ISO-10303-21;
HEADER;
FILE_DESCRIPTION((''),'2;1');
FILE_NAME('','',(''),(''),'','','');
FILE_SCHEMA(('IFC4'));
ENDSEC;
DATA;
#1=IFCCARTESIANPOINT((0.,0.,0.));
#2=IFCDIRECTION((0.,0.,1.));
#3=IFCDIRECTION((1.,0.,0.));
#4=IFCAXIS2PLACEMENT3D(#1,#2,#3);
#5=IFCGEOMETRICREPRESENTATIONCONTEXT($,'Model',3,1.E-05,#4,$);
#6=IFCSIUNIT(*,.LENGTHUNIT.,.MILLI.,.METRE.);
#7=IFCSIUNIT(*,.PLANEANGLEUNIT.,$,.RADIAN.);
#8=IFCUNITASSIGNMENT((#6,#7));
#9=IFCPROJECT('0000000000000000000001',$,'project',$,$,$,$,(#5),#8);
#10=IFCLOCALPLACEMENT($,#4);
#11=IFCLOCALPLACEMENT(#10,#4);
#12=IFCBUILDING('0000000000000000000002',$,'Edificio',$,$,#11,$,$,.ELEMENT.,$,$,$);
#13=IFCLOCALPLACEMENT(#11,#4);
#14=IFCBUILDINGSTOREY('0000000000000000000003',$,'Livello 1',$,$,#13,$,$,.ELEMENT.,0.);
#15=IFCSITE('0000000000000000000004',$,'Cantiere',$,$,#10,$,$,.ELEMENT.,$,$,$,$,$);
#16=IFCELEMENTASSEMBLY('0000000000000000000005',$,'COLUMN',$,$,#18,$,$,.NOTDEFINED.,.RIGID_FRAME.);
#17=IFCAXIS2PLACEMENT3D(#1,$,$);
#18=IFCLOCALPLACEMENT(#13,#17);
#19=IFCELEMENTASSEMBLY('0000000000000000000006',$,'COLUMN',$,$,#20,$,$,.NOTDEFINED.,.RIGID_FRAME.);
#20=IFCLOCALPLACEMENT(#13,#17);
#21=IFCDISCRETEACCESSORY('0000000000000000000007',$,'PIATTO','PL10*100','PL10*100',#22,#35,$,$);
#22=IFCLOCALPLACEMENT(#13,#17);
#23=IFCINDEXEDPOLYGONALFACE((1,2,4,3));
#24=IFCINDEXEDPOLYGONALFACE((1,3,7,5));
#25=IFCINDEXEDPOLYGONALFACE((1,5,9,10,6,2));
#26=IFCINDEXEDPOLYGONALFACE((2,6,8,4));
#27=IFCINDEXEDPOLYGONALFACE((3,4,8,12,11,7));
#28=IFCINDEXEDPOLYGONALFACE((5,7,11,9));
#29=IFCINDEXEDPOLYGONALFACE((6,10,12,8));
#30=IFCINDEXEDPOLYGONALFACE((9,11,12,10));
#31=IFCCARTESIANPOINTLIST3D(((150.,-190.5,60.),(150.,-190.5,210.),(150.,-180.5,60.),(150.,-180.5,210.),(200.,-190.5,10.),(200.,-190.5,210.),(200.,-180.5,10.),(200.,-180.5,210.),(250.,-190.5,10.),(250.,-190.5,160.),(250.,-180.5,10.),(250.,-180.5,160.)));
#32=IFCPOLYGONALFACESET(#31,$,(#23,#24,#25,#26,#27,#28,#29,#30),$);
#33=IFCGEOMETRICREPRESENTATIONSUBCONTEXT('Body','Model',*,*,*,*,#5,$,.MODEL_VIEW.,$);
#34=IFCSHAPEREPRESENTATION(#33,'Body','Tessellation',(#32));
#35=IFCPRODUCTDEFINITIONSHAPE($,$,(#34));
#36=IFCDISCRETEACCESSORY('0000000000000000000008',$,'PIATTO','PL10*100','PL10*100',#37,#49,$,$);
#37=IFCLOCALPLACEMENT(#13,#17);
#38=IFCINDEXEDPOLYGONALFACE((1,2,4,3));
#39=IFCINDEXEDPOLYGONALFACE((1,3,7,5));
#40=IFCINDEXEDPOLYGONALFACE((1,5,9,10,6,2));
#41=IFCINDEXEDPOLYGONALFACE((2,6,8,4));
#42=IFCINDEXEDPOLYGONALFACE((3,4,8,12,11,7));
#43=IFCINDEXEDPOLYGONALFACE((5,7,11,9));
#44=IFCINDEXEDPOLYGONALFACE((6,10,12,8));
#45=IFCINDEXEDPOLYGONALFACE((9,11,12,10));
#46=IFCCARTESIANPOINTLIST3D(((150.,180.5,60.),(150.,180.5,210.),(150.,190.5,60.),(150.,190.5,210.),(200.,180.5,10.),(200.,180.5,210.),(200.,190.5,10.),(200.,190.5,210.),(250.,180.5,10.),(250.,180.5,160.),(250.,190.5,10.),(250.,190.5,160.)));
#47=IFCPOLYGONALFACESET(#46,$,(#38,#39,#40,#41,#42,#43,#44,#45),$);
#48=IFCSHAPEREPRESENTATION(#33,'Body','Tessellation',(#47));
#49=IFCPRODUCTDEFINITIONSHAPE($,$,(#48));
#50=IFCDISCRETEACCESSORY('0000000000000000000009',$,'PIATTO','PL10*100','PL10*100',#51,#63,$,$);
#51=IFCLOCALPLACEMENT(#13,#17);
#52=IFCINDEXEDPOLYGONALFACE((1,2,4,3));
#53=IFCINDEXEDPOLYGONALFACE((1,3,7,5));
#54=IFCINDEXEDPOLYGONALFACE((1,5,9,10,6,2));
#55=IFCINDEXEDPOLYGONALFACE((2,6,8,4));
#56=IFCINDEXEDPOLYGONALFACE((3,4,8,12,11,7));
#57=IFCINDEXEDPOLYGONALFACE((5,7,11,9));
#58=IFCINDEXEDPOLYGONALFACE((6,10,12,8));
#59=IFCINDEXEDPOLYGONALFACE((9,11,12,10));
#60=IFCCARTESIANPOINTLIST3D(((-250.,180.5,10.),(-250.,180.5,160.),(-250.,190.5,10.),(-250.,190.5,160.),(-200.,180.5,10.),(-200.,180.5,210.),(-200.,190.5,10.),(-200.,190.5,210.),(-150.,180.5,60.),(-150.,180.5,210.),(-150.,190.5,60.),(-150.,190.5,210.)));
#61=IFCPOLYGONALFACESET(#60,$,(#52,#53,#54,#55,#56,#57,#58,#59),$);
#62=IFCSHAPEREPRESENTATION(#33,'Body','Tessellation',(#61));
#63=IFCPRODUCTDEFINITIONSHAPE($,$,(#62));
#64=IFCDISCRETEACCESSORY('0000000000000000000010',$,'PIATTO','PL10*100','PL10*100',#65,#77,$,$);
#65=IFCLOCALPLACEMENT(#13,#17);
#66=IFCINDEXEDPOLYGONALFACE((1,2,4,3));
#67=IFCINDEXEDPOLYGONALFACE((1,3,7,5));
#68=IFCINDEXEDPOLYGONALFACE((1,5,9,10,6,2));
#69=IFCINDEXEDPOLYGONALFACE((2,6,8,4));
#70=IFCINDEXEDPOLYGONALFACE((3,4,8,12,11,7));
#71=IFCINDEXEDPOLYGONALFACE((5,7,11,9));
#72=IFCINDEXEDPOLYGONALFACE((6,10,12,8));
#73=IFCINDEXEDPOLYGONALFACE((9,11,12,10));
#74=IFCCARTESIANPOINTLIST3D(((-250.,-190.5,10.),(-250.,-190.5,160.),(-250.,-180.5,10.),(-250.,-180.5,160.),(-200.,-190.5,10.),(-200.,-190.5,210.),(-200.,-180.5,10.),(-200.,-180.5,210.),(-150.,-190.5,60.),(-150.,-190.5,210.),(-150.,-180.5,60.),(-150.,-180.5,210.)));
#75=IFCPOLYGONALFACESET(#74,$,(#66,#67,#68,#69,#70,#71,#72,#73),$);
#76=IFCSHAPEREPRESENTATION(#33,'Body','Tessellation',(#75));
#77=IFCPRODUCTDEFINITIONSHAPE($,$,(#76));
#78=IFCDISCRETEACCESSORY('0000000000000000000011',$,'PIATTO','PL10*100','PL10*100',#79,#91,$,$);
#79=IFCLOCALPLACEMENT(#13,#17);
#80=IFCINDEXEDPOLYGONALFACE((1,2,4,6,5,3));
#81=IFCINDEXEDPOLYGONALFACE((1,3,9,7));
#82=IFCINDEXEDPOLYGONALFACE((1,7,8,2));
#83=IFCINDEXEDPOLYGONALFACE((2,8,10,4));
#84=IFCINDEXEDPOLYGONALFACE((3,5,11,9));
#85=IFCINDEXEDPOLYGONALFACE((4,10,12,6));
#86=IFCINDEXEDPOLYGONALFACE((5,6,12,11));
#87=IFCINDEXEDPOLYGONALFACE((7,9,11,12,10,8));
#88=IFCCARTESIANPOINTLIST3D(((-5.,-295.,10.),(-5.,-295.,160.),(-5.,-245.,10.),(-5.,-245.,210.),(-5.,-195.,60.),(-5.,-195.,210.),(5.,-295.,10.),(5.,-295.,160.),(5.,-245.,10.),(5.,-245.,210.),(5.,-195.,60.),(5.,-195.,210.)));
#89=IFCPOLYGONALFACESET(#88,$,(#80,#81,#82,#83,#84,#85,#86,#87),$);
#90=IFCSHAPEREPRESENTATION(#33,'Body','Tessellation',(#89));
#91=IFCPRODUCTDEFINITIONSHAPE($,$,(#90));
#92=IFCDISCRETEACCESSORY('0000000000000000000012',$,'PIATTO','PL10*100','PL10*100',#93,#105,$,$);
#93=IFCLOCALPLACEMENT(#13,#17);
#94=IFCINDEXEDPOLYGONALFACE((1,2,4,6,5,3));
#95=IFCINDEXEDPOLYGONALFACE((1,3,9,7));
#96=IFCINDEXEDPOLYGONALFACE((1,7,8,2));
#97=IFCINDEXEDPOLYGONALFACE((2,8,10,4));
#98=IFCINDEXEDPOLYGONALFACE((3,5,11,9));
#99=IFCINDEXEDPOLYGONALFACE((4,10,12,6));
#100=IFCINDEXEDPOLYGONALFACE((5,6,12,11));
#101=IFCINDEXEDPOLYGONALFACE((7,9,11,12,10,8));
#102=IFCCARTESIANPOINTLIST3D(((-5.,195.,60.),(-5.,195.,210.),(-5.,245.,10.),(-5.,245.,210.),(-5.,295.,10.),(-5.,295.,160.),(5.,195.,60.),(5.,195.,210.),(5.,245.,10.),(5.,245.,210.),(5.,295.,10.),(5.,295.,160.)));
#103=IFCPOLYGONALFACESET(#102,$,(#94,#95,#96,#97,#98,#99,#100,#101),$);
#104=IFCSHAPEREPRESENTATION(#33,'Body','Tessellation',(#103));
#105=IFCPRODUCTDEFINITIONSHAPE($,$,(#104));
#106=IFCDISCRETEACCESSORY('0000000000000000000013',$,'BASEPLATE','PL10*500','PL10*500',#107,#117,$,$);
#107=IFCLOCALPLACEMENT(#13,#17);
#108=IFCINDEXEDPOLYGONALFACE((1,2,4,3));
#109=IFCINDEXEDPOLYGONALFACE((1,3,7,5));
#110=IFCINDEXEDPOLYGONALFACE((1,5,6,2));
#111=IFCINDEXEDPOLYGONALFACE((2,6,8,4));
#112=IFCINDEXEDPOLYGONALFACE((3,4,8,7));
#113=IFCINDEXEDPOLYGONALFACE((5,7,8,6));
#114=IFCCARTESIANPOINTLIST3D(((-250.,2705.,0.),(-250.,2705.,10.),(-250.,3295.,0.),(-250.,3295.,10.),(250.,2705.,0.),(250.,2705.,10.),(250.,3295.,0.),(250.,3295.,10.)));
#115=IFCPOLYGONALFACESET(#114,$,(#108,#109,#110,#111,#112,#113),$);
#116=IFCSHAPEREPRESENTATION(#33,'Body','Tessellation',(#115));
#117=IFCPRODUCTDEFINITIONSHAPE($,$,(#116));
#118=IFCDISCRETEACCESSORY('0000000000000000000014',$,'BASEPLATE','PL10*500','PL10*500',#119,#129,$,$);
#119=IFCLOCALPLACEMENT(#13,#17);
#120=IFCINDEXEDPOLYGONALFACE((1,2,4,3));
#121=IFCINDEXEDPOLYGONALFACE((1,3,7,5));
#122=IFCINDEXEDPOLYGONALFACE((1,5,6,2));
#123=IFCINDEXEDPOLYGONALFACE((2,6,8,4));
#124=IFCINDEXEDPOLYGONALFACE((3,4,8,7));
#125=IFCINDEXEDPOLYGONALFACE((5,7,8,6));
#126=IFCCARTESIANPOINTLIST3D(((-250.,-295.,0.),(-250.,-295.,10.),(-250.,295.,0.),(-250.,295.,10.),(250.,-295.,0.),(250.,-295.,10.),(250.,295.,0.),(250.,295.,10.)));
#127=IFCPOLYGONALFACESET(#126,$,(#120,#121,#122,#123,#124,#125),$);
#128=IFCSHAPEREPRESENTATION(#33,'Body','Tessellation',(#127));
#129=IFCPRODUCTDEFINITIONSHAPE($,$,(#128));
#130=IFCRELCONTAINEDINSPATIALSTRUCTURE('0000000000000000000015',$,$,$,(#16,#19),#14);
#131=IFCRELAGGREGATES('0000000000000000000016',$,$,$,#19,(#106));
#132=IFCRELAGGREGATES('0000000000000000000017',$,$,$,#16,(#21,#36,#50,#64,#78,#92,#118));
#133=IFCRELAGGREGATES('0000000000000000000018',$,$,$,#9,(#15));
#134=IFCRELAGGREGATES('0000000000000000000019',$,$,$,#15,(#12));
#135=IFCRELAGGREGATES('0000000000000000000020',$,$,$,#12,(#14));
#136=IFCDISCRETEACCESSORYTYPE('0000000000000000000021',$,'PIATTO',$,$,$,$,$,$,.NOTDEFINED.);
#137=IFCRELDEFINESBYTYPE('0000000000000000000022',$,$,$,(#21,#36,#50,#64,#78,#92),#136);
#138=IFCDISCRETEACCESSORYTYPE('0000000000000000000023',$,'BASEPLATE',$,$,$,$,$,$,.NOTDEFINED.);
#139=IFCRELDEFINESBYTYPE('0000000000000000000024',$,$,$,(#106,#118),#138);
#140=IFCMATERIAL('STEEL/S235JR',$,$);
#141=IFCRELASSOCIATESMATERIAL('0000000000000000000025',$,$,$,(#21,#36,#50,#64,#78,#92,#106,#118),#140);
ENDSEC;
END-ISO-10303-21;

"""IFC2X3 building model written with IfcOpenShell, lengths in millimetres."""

from ifc_helpers import new_model, si_unit, frame, origin_with_axes, place, context, subcontext, project, spatial, polyline, outline, extrude, material, type_object, element, aggregate, save


model = new_model("IFC2X3")

# Units and contexts
model_context = context("Model", 3, precision=1e-05, world=origin_with_axes())
body_context = subcontext(model_context, "Body", "Model", "MODEL_VIEW")
ifc_project = project(units=[si_unit("LENGTHUNIT", "METRE", prefix="MILLI"), si_unit("PLANEANGLEUNIT", "RADIAN")], contexts=[model_context])

# Site, building, storey
site_placement = place(None, origin_with_axes())
site = spatial("IfcSite", under=ifc_project, at=site_placement, Name="Cantiere", CompositionType="ELEMENT")
building_placement = place(site_placement, origin_with_axes())
building = spatial("IfcBuilding", under=site, at=building_placement, Name="Edificio", CompositionType="ELEMENT")
storey_placement = place(building_placement, origin_with_axes())
storey = spatial("IfcBuildingStorey", under=building, at=storey_placement, Name="Livello 1", CompositionType="ELEMENT", Elevation=0.0)

# Element assembly
assembly_1_placement = place(storey_placement, origin_with_axes())
assembly_1 = element("IfcElementAssembly", 1, at=assembly_1_placement, inside=storey, Name="COLUMN", AssemblyPlace="NOTDEFINED", PredefinedType="RIGID_FRAME")
ifc_material_1 = material(Name="STEEL/S235JR")

# Element assembly
assembly_2_placement = place(storey_placement, origin_with_axes())
assembly_2 = element("IfcElementAssembly", 2, at=assembly_2_placement, inside=storey, Name="COLUMN", AssemblyPlace="NOTDEFINED", PredefinedType="RIGID_FRAME")
discrete_accessory_type_1 = type_object("IfcDiscreteAccessoryType", Name="PIATTO")

# Discrete accessories
discrete_accessory_1_placement = place(assembly_1_placement, frame((150.0, -185.5, 60.0), z_axis=(0.0, -1.0, 0.0), x_axis=(0.707107, 0.0, -0.707107)))
discrete_accessory_1 = element("IfcDiscreteAccessory", 3, at=discrete_accessory_1_placement, type_object=discrete_accessory_type_1, material=ifc_material_1, Name="PIATTO", Description="PL10*100", ObjectType="PL10*100", context=body_context, shape_type="SweptSolid", body=[
    extrude(outline(polyline([(0.0, 0.0), (70.7, 0.0), (106.1, 35.4), (0.0, 141.4), (-70.7, 141.4), (-106.1, 106.1), (0.0, 0.0)])), frame((0.0, 0.0, -5.0), z_axis=(0.0, 0.0, 1.0), x_axis=(1.0, 0.0, 0.0)), (0.0, 0.0, 1.0), 10.0),
])
discrete_accessory_2_placement = place(assembly_1_placement, frame((150.0, 185.5, 60.0), z_axis=(0.0, -1.0, 0.0), x_axis=(0.707107, 0.0, -0.707107)))
discrete_accessory_2 = element("IfcDiscreteAccessory", 4, at=discrete_accessory_2_placement, type_object=discrete_accessory_type_1, material=ifc_material_1, Name="PIATTO", Description="PL10*100", ObjectType="PL10*100", context=body_context, shape_type="SweptSolid", body=[
    extrude(outline(polyline([(0.0, 0.0), (70.7, 0.0), (106.1, 35.4), (0.0, 141.4), (-70.7, 141.4), (-106.1, 106.1), (0.0, 0.0)])), frame((0.0, 0.0, -5.0), z_axis=(0.0, 0.0, 1.0), x_axis=(1.0, 0.0, 0.0)), (0.0, 0.0, 1.0), 10.0),
])
discrete_accessory_3_placement = place(assembly_1_placement, frame((-150.0, 185.5, 60.0), z_axis=(0.0, 1.0, 0.0), x_axis=(-0.707107, 0.0, -0.707107)))
discrete_accessory_3 = element("IfcDiscreteAccessory", 5, at=discrete_accessory_3_placement, type_object=discrete_accessory_type_1, material=ifc_material_1, Name="PIATTO", Description="PL10*100", ObjectType="PL10*100", context=body_context, shape_type="SweptSolid", body=[
    extrude(outline(polyline([(0.0, 0.0), (70.7, 0.0), (106.1, 35.4), (0.0, 141.4), (-70.7, 141.4), (-106.1, 106.1), (0.0, 0.0)])), frame((0.0, 0.0, -5.0), z_axis=(0.0, 0.0, 1.0), x_axis=(1.0, 0.0, 0.0)), (0.0, 0.0, 1.0), 10.0),
])
discrete_accessory_4_placement = place(assembly_1_placement, frame((-150.0, -185.5, 60.0), z_axis=(0.0, 1.0, 0.0), x_axis=(-0.707107, 0.0, -0.707107)))
discrete_accessory_4 = element("IfcDiscreteAccessory", 6, at=discrete_accessory_4_placement, type_object=discrete_accessory_type_1, material=ifc_material_1, Name="PIATTO", Description="PL10*100", ObjectType="PL10*100", context=body_context, shape_type="SweptSolid", body=[
    extrude(outline(polyline([(0.0, 0.0), (70.7, 0.0), (106.1, 35.4), (0.0, 141.4), (-70.7, 141.4), (-106.1, 106.1), (0.0, 0.0)])), frame((0.0, 0.0, -5.0), z_axis=(0.0, 0.0, 1.0), x_axis=(1.0, 0.0, 0.0)), (0.0, 0.0, 1.0), 10.0),
])
discrete_accessory_5_placement = place(assembly_1_placement, frame((0.0, -195.0, 60.0), z_axis=(-1.0, 0.0, 0.0), x_axis=(0.0, -0.707107, -0.707107)))
discrete_accessory_5 = element("IfcDiscreteAccessory", 7, at=discrete_accessory_5_placement, type_object=discrete_accessory_type_1, material=ifc_material_1, Name="PIATTO", Description="PL10*100", ObjectType="PL10*100", context=body_context, shape_type="SweptSolid", body=[
    extrude(outline(polyline([(0.0, 0.0), (70.7, 0.0), (106.1, 35.4), (0.0, 141.4), (-70.7, 141.4), (-106.1, 106.1), (0.0, 0.0)])), frame((0.0, 0.0, -5.0), z_axis=(0.0, 0.0, 1.0), x_axis=(1.0, 0.0, 0.0)), (0.0, 0.0, 1.0), 10.0),
])
discrete_accessory_6_placement = place(assembly_1_placement, frame((0.0, 195.0, 60.0), z_axis=(1.0, 0.0, 0.0), x_axis=(0.0, 0.707107, -0.707107)))
discrete_accessory_6 = element("IfcDiscreteAccessory", 8, at=discrete_accessory_6_placement, type_object=discrete_accessory_type_1, material=ifc_material_1, Name="PIATTO", Description="PL10*100", ObjectType="PL10*100", context=body_context, shape_type="SweptSolid", body=[
    extrude(outline(polyline([(0.0, 0.0), (70.7, 0.0), (106.1, 35.4), (0.0, 141.4), (-70.7, 141.4), (-106.1, 106.1), (0.0, 0.0)])), frame((0.0, 0.0, -5.0), z_axis=(0.0, 0.0, 1.0), x_axis=(1.0, 0.0, 0.0)), (0.0, 0.0, 1.0), 10.0),
])

# Discrete accessories
discrete_accessory_type_2 = type_object("IfcDiscreteAccessoryType", Name="BASEPLATE")
discrete_accessory_7_placement = place(assembly_2_placement, frame((0.0, 2705.0, 5.0), z_axis=(0.0, 0.0, 1.0), x_axis=(0.0, 1.0, 0.0)))
discrete_accessory_7 = element("IfcDiscreteAccessory", 9, at=discrete_accessory_7_placement, type_object=discrete_accessory_type_2, material=ifc_material_1, Name="BASEPLATE", Description="PL10*500", ObjectType="PL10*500", context=body_context, shape_type="SweptSolid", body=[
    extrude(outline(polyline([(0.0, 250.0), (590.0, 250.0), (590.0, -250.0), (0.0, -250.0), (0.0, 250.0)])), frame((0.0, 0.0, -5.0), z_axis=(0.0, 0.0, 1.0), x_axis=(1.0, 0.0, 0.0)), (0.0, 0.0, 1.0), 10.0),
])
aggregate(assembly_2, [discrete_accessory_7])
discrete_accessory_8_placement = place(assembly_1_placement, frame((0.0, -295.0, 5.0), z_axis=(0.0, 0.0, 1.0), x_axis=(0.0, 1.0, 0.0)))
discrete_accessory_8 = element("IfcDiscreteAccessory", 10, at=discrete_accessory_8_placement, type_object=discrete_accessory_type_2, material=ifc_material_1, Name="BASEPLATE", Description="PL10*500", ObjectType="PL10*500", context=body_context, shape_type="SweptSolid", body=[
    extrude(outline(polyline([(0.0, 250.0), (590.0, 250.0), (590.0, -250.0), (0.0, -250.0), (0.0, 250.0)])), frame((0.0, 0.0, -5.0), z_axis=(0.0, 0.0, 1.0), x_axis=(1.0, 0.0, 0.0)), (0.0, 0.0, 1.0), 10.0),
])
aggregate(assembly_1, [discrete_accessory_1, discrete_accessory_2, discrete_accessory_3, discrete_accessory_4, discrete_accessory_5, discrete_accessory_6, discrete_accessory_8])

save(model, "model.ifc")
